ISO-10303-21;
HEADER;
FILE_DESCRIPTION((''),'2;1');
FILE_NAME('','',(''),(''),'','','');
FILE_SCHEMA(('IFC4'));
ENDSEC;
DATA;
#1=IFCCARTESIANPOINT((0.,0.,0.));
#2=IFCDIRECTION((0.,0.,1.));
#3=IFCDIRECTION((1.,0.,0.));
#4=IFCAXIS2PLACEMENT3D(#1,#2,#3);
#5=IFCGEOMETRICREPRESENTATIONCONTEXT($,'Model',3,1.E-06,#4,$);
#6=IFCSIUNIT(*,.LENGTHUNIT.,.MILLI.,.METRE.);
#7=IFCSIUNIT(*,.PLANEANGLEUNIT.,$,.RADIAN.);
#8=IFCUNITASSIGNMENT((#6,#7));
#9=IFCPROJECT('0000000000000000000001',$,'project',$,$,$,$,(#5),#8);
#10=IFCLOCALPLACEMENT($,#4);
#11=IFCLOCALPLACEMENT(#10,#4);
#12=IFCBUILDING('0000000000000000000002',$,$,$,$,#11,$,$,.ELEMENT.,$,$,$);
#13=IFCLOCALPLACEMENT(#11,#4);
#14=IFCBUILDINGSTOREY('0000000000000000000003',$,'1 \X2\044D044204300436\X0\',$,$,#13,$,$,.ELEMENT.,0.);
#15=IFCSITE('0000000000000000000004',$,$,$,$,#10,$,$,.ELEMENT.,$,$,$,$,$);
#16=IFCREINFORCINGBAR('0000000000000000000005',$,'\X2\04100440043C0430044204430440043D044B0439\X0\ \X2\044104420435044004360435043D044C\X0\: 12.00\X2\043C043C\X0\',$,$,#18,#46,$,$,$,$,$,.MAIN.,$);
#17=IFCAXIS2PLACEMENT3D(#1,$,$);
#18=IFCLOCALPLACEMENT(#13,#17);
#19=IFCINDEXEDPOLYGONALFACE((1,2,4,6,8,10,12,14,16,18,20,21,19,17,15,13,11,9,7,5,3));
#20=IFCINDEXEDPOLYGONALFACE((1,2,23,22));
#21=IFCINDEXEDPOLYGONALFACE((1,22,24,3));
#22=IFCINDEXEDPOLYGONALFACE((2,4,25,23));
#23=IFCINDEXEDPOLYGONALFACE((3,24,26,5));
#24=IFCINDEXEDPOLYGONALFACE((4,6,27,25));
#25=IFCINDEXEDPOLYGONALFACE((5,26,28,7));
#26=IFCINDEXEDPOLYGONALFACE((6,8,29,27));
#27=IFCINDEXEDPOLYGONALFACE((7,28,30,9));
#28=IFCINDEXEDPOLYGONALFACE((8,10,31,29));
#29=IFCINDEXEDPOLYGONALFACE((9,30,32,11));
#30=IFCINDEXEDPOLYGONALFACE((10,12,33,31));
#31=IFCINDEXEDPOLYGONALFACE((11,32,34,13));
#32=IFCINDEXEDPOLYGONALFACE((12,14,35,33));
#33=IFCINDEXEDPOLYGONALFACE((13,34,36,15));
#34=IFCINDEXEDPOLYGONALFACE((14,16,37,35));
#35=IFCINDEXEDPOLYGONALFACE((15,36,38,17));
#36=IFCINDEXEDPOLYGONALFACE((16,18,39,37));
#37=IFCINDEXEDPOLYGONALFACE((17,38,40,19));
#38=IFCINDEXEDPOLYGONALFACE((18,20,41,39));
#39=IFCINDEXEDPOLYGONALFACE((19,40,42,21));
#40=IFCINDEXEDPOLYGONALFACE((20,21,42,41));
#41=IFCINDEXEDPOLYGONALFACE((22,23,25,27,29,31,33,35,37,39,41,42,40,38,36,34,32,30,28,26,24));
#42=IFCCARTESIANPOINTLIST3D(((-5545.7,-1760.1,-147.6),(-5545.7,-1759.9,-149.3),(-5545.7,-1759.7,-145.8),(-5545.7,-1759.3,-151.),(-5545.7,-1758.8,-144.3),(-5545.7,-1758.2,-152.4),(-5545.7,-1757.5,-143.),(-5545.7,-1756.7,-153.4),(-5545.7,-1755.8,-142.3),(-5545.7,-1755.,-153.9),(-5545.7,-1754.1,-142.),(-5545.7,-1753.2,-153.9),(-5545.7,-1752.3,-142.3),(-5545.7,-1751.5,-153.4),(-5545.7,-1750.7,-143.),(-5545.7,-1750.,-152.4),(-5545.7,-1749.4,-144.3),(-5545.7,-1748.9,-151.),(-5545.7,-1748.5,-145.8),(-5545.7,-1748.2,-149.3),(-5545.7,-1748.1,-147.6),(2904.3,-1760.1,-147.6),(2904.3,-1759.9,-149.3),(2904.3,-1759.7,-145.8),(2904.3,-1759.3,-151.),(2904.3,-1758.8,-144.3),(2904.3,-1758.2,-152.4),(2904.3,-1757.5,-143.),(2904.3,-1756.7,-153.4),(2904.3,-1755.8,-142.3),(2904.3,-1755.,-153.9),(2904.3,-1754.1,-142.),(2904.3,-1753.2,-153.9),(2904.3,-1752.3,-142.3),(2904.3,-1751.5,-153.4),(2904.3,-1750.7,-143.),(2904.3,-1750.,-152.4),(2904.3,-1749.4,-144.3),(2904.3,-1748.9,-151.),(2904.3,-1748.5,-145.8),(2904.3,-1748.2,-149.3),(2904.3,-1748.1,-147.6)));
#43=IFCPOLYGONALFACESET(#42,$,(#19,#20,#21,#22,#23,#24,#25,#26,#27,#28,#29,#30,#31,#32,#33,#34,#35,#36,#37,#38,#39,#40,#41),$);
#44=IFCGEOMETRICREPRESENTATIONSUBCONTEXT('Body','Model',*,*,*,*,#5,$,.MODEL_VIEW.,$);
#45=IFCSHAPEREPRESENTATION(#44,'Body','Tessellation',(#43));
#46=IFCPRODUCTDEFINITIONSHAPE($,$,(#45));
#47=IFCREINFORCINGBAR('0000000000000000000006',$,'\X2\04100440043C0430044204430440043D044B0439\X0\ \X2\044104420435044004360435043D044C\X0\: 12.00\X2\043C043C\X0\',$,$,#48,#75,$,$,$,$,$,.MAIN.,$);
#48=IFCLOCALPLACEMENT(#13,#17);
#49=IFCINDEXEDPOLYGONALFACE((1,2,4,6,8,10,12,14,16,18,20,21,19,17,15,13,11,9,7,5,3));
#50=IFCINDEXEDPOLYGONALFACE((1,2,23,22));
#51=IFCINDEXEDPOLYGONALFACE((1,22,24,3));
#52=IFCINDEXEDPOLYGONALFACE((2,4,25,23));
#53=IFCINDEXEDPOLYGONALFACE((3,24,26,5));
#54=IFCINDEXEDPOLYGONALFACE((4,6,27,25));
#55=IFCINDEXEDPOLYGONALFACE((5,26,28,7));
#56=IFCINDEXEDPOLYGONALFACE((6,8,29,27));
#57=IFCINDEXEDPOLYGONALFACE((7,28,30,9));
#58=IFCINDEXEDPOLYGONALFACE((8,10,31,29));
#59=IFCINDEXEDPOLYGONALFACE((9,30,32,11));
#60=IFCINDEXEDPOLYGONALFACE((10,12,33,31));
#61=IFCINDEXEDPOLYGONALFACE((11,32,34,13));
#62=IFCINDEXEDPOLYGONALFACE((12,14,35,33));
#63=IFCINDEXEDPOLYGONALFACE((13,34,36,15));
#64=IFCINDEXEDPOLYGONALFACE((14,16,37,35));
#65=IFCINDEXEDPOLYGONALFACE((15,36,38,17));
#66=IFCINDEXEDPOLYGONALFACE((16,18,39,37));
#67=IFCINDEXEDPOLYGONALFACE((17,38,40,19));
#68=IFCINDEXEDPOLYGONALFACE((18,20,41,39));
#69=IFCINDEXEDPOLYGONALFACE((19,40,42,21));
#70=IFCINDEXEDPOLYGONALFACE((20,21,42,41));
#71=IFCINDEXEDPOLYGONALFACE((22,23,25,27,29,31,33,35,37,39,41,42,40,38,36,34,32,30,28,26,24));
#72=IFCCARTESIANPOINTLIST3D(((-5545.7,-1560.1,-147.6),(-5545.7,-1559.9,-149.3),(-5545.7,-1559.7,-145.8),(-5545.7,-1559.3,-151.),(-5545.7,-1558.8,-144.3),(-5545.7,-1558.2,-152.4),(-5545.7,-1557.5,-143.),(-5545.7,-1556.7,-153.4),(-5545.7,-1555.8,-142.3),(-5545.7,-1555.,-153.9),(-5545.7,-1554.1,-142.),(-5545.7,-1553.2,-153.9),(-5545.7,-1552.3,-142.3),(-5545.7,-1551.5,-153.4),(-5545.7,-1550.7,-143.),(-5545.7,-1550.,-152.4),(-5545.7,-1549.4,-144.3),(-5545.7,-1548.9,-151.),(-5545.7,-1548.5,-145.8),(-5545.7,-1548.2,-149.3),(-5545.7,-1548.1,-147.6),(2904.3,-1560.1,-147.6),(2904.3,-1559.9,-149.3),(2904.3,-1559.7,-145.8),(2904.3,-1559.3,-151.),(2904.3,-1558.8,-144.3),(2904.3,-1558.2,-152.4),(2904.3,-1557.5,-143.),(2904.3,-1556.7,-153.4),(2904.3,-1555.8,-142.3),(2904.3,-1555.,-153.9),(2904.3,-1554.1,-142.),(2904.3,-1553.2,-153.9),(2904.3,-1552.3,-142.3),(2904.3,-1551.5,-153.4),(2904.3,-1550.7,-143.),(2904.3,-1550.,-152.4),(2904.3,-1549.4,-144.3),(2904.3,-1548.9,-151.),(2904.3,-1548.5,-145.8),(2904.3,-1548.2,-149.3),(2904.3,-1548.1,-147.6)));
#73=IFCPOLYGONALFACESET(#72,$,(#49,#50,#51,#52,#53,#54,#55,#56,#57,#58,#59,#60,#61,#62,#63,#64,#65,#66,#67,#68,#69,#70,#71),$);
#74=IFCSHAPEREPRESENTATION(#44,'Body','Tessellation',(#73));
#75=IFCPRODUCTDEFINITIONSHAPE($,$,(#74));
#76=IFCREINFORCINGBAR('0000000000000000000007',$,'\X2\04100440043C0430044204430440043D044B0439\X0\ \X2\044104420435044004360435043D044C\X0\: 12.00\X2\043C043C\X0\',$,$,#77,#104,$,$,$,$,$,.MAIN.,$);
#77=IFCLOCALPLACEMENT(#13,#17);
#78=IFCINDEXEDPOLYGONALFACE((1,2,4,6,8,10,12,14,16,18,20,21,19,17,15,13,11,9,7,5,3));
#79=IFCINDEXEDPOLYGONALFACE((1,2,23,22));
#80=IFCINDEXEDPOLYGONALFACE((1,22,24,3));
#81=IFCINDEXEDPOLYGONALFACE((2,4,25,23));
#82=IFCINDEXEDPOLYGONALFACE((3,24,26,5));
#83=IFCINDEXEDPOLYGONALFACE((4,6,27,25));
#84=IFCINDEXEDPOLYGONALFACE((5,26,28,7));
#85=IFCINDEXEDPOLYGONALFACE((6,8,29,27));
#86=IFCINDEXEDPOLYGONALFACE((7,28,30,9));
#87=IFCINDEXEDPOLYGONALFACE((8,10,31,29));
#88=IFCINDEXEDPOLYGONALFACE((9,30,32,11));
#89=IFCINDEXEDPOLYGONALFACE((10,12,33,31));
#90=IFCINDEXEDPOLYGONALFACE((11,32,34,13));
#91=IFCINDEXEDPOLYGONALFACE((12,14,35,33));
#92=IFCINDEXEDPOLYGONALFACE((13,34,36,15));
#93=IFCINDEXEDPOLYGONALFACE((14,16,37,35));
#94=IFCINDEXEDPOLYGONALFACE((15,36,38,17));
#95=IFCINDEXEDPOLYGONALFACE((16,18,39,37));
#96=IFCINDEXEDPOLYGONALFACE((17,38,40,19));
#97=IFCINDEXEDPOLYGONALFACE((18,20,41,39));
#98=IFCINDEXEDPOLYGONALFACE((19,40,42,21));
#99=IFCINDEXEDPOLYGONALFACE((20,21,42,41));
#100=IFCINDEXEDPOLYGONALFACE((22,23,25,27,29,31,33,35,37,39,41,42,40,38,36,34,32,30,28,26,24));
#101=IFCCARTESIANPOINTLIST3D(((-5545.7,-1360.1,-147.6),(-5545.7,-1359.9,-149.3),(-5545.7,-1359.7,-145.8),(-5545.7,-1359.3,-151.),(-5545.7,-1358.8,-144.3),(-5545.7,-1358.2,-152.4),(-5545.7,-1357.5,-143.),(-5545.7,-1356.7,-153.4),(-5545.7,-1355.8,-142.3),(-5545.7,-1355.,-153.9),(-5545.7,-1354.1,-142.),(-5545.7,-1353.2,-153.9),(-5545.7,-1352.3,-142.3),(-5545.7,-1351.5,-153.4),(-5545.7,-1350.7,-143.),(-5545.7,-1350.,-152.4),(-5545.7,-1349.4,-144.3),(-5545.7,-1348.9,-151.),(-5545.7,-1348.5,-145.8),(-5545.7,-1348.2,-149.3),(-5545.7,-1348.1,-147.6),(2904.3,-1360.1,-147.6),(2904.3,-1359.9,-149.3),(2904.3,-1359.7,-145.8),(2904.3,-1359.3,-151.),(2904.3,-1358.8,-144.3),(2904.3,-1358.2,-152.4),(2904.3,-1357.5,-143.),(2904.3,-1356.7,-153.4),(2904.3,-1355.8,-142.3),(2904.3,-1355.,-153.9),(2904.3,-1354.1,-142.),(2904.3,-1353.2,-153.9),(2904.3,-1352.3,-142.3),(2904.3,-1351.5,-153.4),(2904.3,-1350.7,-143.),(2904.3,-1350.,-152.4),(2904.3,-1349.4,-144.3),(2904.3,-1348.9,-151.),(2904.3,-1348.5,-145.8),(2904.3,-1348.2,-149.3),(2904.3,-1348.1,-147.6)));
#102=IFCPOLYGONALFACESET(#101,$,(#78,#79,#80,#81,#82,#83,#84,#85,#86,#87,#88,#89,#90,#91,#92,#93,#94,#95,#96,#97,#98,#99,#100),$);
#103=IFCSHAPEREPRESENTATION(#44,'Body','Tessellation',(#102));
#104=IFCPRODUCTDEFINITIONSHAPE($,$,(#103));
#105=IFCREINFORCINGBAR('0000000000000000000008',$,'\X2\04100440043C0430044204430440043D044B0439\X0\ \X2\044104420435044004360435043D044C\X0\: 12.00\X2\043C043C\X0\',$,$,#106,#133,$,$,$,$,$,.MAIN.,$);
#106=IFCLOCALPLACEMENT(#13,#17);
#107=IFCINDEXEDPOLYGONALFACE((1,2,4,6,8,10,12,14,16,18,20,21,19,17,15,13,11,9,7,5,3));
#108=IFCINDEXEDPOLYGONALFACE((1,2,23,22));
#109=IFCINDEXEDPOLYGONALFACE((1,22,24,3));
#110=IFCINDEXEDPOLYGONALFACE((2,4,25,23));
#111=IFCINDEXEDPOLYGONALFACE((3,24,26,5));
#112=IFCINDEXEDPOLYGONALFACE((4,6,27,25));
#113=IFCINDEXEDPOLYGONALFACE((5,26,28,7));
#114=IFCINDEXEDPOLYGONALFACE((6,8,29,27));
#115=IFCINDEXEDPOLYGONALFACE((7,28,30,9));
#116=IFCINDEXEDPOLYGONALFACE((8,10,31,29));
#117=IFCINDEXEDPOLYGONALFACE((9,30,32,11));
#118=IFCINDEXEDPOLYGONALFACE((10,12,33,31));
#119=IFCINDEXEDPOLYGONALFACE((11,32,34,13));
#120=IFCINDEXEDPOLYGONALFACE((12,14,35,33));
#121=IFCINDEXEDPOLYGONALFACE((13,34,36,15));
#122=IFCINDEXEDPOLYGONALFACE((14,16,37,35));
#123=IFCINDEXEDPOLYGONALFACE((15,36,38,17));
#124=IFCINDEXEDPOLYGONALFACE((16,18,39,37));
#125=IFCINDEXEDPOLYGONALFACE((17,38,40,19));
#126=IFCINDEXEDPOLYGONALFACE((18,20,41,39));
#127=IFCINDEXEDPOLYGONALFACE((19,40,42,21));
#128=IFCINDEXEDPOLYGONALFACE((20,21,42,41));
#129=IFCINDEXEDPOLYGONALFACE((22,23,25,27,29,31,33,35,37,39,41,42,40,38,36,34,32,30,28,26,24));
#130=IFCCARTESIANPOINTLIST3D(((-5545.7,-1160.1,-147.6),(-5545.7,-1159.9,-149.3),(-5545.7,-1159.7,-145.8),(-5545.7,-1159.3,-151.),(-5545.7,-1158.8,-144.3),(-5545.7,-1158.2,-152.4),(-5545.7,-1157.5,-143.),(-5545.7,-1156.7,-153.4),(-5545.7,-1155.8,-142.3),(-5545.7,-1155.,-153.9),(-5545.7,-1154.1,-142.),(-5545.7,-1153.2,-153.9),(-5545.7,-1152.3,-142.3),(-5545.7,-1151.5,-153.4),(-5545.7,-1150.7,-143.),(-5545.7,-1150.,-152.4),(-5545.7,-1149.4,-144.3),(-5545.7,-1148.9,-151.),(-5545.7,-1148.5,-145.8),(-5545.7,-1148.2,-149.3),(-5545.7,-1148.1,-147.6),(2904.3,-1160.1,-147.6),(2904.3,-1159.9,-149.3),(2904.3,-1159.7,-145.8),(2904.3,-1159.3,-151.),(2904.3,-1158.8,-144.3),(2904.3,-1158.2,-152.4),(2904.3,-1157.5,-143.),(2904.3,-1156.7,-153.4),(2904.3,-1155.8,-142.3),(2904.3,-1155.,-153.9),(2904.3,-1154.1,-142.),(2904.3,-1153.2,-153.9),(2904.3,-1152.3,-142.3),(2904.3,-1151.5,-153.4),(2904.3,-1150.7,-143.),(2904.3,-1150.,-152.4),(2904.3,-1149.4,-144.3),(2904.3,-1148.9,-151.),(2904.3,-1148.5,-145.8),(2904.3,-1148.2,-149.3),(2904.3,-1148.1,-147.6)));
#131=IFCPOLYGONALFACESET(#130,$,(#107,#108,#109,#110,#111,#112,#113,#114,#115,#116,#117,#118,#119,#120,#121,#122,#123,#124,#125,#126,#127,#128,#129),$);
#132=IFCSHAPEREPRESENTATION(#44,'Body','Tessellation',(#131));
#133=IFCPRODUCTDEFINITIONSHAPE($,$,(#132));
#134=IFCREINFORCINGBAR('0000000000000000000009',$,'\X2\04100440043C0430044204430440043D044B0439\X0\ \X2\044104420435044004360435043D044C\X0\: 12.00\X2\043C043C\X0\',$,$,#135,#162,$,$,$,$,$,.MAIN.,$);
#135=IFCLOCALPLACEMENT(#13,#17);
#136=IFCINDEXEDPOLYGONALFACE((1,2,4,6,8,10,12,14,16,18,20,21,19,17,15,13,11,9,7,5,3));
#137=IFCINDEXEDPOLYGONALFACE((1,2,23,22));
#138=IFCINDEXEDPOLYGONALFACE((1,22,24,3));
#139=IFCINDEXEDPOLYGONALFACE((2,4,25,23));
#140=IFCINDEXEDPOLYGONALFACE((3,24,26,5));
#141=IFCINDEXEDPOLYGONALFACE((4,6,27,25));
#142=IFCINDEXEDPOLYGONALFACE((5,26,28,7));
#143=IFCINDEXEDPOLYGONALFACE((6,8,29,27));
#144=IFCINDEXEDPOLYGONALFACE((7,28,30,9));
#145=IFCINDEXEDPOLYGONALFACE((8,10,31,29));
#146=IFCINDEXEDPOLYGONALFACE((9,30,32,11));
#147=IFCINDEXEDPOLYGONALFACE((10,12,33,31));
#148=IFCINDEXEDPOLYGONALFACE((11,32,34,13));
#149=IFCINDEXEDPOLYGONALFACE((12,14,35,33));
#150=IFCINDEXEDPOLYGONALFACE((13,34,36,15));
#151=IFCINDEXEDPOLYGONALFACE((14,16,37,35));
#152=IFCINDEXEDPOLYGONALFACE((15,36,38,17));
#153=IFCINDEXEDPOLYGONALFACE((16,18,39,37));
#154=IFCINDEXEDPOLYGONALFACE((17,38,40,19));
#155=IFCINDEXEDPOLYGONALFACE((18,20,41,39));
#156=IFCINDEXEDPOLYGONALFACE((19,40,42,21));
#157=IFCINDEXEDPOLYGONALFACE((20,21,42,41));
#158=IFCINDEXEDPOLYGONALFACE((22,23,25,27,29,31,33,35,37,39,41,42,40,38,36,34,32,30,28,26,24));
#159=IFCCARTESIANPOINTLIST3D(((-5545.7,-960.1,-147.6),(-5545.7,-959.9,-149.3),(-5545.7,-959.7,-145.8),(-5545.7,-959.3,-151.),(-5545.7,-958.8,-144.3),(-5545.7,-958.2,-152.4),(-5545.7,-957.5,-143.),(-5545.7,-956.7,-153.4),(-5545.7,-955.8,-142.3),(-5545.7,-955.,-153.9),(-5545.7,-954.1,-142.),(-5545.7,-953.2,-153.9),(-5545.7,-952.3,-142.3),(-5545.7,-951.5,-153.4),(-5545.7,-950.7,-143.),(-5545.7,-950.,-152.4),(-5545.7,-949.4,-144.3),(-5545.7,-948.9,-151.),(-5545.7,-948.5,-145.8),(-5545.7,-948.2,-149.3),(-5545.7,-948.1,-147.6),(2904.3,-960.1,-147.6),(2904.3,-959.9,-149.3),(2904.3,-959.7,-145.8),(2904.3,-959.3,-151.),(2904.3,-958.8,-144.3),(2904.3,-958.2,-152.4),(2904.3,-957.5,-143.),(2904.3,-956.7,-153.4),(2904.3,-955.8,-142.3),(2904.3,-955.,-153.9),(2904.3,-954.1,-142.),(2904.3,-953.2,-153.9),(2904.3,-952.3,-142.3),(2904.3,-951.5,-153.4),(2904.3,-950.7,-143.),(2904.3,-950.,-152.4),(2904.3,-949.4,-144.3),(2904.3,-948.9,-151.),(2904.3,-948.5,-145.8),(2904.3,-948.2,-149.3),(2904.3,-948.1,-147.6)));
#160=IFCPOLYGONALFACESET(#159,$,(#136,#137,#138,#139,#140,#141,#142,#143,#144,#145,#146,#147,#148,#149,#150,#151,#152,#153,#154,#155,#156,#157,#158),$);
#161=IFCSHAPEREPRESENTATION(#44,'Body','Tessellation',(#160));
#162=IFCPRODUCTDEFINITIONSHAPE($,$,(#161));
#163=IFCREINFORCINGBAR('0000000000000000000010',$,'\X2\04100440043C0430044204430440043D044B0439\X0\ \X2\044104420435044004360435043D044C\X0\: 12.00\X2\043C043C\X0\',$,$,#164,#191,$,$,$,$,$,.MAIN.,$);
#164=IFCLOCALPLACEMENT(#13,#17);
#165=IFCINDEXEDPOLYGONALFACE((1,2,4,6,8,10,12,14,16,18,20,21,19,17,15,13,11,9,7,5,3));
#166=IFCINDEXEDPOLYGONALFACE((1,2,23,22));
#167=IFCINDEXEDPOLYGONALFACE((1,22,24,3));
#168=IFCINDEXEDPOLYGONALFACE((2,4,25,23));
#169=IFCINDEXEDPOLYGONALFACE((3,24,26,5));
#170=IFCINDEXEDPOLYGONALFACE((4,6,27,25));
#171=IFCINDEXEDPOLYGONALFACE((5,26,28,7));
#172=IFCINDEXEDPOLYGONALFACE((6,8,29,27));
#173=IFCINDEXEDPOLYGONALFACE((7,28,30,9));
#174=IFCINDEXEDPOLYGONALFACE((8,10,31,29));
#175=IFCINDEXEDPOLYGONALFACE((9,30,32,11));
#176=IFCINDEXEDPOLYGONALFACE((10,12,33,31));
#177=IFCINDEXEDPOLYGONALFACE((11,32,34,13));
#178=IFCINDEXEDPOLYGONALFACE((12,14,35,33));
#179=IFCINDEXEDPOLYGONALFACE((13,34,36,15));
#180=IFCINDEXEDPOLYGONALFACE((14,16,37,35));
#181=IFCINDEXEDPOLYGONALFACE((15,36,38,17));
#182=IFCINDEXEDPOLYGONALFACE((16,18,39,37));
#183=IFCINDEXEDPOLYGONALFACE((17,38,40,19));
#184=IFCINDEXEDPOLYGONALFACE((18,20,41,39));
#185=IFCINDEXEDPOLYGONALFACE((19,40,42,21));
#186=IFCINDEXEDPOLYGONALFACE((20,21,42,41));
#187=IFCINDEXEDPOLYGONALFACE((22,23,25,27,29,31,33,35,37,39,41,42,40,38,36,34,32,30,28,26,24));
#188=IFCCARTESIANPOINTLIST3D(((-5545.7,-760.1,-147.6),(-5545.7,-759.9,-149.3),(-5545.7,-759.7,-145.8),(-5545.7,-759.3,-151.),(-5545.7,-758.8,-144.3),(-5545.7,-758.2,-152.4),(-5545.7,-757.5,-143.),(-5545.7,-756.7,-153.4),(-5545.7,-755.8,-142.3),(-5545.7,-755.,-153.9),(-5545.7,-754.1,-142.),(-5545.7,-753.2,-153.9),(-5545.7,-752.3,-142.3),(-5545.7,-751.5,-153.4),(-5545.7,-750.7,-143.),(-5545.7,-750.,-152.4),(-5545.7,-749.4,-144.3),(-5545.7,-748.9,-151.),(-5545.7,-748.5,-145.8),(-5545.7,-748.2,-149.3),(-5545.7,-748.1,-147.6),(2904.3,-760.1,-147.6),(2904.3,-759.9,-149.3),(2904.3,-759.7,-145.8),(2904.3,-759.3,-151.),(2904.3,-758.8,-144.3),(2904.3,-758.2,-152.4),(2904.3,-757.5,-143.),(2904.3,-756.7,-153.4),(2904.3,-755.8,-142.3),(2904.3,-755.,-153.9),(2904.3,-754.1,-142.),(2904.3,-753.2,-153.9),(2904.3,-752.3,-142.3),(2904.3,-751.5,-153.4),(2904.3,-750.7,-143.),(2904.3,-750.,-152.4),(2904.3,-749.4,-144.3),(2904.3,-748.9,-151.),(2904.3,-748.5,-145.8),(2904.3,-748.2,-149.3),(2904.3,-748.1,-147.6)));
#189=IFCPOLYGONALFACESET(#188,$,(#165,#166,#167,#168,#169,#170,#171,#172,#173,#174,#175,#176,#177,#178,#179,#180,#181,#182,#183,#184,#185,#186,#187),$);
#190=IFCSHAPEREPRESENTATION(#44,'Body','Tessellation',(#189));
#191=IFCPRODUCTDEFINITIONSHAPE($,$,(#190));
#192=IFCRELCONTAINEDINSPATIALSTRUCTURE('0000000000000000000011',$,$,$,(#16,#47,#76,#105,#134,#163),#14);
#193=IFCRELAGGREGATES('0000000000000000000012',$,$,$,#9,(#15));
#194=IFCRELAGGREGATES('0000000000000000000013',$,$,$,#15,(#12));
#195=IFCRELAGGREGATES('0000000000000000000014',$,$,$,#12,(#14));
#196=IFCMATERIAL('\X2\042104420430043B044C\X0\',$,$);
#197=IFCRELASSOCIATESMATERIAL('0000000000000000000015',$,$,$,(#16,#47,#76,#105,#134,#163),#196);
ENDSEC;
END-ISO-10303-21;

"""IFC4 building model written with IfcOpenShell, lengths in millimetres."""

from ifc_helpers import new_model, entity, si_unit, origin_with_axes, place, context, subcontext, project, spatial, source, transform, mapped, material, element, save


model = new_model("IFC4")

# Units and contexts
model_context = context("Model", 3, precision=1e-06, world=origin_with_axes())
body_context = subcontext(model_context, "Body", "Model", "MODEL_VIEW")
ifc_project = project(units=[si_unit("LENGTHUNIT", "METRE", prefix="MILLI"), si_unit("PLANEANGLEUNIT", "RADIAN")], contexts=[model_context])

# Site, building, storey
site_placement = place(None, origin_with_axes())
site = spatial("IfcSite", under=ifc_project, at=site_placement, CompositionType="ELEMENT")
building_placement = place(site_placement, origin_with_axes())
building = spatial("IfcBuilding", under=site, at=building_placement, CompositionType="ELEMENT")
storey_placement = place(building_placement, origin_with_axes())
storey = spatial("IfcBuildingStorey", under=building, at=storey_placement, Name="1 этаж", CompositionType="ELEMENT", Elevation=0.0)

# Reinforcing bars
ifc_material = material(Name="Сталь")
shared_shape = source(origin_with_axes(), body_context, "Body", "AdvancedSweptSolid", [
    entity("IfcSweptDiskSolid", entity("IfcIndexedPolyCurve", entity("IfcCartesianPointList3D", [[0.0, 0.0, 0.0], [8450.0, 0.0, 0.0]]), [entity("IfcLineIndex", [1, 2])]), 6.0),
])
reinforcing_bar_1_placement = place(storey_placement, origin_with_axes())
element("IfcReinforcingBar", 1, at=reinforcing_bar_1_placement, inside=storey, material=ifc_material, Name="Арматурный стержень: 12.00мм", PredefinedType="MAIN", context=body_context, shape_type="MappedRepresentation", body=[
    mapped(shared_shape, transform((-5545.7, -1754.1, -148.0), x_axis=(1.0, 0.0, 0.0), y_axis=(0.0, 1.0, 0.0), z_axis=(0.0, 0.0, 1.0), scale=1.0)),
])
reinforcing_bar_2_placement = place(storey_placement, origin_with_axes())
element("IfcReinforcingBar", 2, at=reinforcing_bar_2_placement, inside=storey, material=ifc_material, Name="Арматурный стержень: 12.00мм", PredefinedType="MAIN", context=body_context, shape_type="MappedRepresentation", body=[
    mapped(shared_shape, transform((-5545.7, -1554.1, -148.0), x_axis=(1.0, 0.0, 0.0), y_axis=(0.0, 1.0, 0.0), z_axis=(0.0, 0.0, 1.0), scale=1.0)),
])
reinforcing_bar_3_placement = place(storey_placement, origin_with_axes())
element("IfcReinforcingBar", 3, at=reinforcing_bar_3_placement, inside=storey, material=ifc_material, Name="Арматурный стержень: 12.00мм", PredefinedType="MAIN", context=body_context, shape_type="MappedRepresentation", body=[
    mapped(shared_shape, transform((-5545.7, -1354.1, -148.0), x_axis=(1.0, 0.0, 0.0), y_axis=(0.0, 1.0, 0.0), z_axis=(0.0, 0.0, 1.0), scale=1.0)),
])
reinforcing_bar_4_placement = place(storey_placement, origin_with_axes())
element("IfcReinforcingBar", 4, at=reinforcing_bar_4_placement, inside=storey, material=ifc_material, Name="Арматурный стержень: 12.00мм", PredefinedType="MAIN", context=body_context, shape_type="MappedRepresentation", body=[
    mapped(shared_shape, transform((-5545.7, -1154.1, -148.0), x_axis=(1.0, 0.0, 0.0), y_axis=(0.0, 1.0, 0.0), z_axis=(0.0, 0.0, 1.0), scale=1.0)),
])
reinforcing_bar_5_placement = place(storey_placement, origin_with_axes())
element("IfcReinforcingBar", 5, at=reinforcing_bar_5_placement, inside=storey, material=ifc_material, Name="Арматурный стержень: 12.00мм", PredefinedType="MAIN", context=body_context, shape_type="MappedRepresentation", body=[
    mapped(shared_shape, transform((-5545.7, -954.1, -148.0), x_axis=(1.0, 0.0, 0.0), y_axis=(0.0, 1.0, 0.0), z_axis=(0.0, 0.0, 1.0), scale=1.0)),
])
reinforcing_bar_6_placement = place(storey_placement, origin_with_axes())
element("IfcReinforcingBar", 6, at=reinforcing_bar_6_placement, inside=storey, material=ifc_material, Name="Арматурный стержень: 12.00мм", PredefinedType="MAIN", context=body_context, shape_type="MappedRepresentation", body=[
    mapped(shared_shape, transform((-5545.7, -754.1, -148.0), x_axis=(1.0, 0.0, 0.0), y_axis=(0.0, 1.0, 0.0), z_axis=(0.0, 0.0, 1.0), scale=1.0)),
])

save(model, "model.ifc")
